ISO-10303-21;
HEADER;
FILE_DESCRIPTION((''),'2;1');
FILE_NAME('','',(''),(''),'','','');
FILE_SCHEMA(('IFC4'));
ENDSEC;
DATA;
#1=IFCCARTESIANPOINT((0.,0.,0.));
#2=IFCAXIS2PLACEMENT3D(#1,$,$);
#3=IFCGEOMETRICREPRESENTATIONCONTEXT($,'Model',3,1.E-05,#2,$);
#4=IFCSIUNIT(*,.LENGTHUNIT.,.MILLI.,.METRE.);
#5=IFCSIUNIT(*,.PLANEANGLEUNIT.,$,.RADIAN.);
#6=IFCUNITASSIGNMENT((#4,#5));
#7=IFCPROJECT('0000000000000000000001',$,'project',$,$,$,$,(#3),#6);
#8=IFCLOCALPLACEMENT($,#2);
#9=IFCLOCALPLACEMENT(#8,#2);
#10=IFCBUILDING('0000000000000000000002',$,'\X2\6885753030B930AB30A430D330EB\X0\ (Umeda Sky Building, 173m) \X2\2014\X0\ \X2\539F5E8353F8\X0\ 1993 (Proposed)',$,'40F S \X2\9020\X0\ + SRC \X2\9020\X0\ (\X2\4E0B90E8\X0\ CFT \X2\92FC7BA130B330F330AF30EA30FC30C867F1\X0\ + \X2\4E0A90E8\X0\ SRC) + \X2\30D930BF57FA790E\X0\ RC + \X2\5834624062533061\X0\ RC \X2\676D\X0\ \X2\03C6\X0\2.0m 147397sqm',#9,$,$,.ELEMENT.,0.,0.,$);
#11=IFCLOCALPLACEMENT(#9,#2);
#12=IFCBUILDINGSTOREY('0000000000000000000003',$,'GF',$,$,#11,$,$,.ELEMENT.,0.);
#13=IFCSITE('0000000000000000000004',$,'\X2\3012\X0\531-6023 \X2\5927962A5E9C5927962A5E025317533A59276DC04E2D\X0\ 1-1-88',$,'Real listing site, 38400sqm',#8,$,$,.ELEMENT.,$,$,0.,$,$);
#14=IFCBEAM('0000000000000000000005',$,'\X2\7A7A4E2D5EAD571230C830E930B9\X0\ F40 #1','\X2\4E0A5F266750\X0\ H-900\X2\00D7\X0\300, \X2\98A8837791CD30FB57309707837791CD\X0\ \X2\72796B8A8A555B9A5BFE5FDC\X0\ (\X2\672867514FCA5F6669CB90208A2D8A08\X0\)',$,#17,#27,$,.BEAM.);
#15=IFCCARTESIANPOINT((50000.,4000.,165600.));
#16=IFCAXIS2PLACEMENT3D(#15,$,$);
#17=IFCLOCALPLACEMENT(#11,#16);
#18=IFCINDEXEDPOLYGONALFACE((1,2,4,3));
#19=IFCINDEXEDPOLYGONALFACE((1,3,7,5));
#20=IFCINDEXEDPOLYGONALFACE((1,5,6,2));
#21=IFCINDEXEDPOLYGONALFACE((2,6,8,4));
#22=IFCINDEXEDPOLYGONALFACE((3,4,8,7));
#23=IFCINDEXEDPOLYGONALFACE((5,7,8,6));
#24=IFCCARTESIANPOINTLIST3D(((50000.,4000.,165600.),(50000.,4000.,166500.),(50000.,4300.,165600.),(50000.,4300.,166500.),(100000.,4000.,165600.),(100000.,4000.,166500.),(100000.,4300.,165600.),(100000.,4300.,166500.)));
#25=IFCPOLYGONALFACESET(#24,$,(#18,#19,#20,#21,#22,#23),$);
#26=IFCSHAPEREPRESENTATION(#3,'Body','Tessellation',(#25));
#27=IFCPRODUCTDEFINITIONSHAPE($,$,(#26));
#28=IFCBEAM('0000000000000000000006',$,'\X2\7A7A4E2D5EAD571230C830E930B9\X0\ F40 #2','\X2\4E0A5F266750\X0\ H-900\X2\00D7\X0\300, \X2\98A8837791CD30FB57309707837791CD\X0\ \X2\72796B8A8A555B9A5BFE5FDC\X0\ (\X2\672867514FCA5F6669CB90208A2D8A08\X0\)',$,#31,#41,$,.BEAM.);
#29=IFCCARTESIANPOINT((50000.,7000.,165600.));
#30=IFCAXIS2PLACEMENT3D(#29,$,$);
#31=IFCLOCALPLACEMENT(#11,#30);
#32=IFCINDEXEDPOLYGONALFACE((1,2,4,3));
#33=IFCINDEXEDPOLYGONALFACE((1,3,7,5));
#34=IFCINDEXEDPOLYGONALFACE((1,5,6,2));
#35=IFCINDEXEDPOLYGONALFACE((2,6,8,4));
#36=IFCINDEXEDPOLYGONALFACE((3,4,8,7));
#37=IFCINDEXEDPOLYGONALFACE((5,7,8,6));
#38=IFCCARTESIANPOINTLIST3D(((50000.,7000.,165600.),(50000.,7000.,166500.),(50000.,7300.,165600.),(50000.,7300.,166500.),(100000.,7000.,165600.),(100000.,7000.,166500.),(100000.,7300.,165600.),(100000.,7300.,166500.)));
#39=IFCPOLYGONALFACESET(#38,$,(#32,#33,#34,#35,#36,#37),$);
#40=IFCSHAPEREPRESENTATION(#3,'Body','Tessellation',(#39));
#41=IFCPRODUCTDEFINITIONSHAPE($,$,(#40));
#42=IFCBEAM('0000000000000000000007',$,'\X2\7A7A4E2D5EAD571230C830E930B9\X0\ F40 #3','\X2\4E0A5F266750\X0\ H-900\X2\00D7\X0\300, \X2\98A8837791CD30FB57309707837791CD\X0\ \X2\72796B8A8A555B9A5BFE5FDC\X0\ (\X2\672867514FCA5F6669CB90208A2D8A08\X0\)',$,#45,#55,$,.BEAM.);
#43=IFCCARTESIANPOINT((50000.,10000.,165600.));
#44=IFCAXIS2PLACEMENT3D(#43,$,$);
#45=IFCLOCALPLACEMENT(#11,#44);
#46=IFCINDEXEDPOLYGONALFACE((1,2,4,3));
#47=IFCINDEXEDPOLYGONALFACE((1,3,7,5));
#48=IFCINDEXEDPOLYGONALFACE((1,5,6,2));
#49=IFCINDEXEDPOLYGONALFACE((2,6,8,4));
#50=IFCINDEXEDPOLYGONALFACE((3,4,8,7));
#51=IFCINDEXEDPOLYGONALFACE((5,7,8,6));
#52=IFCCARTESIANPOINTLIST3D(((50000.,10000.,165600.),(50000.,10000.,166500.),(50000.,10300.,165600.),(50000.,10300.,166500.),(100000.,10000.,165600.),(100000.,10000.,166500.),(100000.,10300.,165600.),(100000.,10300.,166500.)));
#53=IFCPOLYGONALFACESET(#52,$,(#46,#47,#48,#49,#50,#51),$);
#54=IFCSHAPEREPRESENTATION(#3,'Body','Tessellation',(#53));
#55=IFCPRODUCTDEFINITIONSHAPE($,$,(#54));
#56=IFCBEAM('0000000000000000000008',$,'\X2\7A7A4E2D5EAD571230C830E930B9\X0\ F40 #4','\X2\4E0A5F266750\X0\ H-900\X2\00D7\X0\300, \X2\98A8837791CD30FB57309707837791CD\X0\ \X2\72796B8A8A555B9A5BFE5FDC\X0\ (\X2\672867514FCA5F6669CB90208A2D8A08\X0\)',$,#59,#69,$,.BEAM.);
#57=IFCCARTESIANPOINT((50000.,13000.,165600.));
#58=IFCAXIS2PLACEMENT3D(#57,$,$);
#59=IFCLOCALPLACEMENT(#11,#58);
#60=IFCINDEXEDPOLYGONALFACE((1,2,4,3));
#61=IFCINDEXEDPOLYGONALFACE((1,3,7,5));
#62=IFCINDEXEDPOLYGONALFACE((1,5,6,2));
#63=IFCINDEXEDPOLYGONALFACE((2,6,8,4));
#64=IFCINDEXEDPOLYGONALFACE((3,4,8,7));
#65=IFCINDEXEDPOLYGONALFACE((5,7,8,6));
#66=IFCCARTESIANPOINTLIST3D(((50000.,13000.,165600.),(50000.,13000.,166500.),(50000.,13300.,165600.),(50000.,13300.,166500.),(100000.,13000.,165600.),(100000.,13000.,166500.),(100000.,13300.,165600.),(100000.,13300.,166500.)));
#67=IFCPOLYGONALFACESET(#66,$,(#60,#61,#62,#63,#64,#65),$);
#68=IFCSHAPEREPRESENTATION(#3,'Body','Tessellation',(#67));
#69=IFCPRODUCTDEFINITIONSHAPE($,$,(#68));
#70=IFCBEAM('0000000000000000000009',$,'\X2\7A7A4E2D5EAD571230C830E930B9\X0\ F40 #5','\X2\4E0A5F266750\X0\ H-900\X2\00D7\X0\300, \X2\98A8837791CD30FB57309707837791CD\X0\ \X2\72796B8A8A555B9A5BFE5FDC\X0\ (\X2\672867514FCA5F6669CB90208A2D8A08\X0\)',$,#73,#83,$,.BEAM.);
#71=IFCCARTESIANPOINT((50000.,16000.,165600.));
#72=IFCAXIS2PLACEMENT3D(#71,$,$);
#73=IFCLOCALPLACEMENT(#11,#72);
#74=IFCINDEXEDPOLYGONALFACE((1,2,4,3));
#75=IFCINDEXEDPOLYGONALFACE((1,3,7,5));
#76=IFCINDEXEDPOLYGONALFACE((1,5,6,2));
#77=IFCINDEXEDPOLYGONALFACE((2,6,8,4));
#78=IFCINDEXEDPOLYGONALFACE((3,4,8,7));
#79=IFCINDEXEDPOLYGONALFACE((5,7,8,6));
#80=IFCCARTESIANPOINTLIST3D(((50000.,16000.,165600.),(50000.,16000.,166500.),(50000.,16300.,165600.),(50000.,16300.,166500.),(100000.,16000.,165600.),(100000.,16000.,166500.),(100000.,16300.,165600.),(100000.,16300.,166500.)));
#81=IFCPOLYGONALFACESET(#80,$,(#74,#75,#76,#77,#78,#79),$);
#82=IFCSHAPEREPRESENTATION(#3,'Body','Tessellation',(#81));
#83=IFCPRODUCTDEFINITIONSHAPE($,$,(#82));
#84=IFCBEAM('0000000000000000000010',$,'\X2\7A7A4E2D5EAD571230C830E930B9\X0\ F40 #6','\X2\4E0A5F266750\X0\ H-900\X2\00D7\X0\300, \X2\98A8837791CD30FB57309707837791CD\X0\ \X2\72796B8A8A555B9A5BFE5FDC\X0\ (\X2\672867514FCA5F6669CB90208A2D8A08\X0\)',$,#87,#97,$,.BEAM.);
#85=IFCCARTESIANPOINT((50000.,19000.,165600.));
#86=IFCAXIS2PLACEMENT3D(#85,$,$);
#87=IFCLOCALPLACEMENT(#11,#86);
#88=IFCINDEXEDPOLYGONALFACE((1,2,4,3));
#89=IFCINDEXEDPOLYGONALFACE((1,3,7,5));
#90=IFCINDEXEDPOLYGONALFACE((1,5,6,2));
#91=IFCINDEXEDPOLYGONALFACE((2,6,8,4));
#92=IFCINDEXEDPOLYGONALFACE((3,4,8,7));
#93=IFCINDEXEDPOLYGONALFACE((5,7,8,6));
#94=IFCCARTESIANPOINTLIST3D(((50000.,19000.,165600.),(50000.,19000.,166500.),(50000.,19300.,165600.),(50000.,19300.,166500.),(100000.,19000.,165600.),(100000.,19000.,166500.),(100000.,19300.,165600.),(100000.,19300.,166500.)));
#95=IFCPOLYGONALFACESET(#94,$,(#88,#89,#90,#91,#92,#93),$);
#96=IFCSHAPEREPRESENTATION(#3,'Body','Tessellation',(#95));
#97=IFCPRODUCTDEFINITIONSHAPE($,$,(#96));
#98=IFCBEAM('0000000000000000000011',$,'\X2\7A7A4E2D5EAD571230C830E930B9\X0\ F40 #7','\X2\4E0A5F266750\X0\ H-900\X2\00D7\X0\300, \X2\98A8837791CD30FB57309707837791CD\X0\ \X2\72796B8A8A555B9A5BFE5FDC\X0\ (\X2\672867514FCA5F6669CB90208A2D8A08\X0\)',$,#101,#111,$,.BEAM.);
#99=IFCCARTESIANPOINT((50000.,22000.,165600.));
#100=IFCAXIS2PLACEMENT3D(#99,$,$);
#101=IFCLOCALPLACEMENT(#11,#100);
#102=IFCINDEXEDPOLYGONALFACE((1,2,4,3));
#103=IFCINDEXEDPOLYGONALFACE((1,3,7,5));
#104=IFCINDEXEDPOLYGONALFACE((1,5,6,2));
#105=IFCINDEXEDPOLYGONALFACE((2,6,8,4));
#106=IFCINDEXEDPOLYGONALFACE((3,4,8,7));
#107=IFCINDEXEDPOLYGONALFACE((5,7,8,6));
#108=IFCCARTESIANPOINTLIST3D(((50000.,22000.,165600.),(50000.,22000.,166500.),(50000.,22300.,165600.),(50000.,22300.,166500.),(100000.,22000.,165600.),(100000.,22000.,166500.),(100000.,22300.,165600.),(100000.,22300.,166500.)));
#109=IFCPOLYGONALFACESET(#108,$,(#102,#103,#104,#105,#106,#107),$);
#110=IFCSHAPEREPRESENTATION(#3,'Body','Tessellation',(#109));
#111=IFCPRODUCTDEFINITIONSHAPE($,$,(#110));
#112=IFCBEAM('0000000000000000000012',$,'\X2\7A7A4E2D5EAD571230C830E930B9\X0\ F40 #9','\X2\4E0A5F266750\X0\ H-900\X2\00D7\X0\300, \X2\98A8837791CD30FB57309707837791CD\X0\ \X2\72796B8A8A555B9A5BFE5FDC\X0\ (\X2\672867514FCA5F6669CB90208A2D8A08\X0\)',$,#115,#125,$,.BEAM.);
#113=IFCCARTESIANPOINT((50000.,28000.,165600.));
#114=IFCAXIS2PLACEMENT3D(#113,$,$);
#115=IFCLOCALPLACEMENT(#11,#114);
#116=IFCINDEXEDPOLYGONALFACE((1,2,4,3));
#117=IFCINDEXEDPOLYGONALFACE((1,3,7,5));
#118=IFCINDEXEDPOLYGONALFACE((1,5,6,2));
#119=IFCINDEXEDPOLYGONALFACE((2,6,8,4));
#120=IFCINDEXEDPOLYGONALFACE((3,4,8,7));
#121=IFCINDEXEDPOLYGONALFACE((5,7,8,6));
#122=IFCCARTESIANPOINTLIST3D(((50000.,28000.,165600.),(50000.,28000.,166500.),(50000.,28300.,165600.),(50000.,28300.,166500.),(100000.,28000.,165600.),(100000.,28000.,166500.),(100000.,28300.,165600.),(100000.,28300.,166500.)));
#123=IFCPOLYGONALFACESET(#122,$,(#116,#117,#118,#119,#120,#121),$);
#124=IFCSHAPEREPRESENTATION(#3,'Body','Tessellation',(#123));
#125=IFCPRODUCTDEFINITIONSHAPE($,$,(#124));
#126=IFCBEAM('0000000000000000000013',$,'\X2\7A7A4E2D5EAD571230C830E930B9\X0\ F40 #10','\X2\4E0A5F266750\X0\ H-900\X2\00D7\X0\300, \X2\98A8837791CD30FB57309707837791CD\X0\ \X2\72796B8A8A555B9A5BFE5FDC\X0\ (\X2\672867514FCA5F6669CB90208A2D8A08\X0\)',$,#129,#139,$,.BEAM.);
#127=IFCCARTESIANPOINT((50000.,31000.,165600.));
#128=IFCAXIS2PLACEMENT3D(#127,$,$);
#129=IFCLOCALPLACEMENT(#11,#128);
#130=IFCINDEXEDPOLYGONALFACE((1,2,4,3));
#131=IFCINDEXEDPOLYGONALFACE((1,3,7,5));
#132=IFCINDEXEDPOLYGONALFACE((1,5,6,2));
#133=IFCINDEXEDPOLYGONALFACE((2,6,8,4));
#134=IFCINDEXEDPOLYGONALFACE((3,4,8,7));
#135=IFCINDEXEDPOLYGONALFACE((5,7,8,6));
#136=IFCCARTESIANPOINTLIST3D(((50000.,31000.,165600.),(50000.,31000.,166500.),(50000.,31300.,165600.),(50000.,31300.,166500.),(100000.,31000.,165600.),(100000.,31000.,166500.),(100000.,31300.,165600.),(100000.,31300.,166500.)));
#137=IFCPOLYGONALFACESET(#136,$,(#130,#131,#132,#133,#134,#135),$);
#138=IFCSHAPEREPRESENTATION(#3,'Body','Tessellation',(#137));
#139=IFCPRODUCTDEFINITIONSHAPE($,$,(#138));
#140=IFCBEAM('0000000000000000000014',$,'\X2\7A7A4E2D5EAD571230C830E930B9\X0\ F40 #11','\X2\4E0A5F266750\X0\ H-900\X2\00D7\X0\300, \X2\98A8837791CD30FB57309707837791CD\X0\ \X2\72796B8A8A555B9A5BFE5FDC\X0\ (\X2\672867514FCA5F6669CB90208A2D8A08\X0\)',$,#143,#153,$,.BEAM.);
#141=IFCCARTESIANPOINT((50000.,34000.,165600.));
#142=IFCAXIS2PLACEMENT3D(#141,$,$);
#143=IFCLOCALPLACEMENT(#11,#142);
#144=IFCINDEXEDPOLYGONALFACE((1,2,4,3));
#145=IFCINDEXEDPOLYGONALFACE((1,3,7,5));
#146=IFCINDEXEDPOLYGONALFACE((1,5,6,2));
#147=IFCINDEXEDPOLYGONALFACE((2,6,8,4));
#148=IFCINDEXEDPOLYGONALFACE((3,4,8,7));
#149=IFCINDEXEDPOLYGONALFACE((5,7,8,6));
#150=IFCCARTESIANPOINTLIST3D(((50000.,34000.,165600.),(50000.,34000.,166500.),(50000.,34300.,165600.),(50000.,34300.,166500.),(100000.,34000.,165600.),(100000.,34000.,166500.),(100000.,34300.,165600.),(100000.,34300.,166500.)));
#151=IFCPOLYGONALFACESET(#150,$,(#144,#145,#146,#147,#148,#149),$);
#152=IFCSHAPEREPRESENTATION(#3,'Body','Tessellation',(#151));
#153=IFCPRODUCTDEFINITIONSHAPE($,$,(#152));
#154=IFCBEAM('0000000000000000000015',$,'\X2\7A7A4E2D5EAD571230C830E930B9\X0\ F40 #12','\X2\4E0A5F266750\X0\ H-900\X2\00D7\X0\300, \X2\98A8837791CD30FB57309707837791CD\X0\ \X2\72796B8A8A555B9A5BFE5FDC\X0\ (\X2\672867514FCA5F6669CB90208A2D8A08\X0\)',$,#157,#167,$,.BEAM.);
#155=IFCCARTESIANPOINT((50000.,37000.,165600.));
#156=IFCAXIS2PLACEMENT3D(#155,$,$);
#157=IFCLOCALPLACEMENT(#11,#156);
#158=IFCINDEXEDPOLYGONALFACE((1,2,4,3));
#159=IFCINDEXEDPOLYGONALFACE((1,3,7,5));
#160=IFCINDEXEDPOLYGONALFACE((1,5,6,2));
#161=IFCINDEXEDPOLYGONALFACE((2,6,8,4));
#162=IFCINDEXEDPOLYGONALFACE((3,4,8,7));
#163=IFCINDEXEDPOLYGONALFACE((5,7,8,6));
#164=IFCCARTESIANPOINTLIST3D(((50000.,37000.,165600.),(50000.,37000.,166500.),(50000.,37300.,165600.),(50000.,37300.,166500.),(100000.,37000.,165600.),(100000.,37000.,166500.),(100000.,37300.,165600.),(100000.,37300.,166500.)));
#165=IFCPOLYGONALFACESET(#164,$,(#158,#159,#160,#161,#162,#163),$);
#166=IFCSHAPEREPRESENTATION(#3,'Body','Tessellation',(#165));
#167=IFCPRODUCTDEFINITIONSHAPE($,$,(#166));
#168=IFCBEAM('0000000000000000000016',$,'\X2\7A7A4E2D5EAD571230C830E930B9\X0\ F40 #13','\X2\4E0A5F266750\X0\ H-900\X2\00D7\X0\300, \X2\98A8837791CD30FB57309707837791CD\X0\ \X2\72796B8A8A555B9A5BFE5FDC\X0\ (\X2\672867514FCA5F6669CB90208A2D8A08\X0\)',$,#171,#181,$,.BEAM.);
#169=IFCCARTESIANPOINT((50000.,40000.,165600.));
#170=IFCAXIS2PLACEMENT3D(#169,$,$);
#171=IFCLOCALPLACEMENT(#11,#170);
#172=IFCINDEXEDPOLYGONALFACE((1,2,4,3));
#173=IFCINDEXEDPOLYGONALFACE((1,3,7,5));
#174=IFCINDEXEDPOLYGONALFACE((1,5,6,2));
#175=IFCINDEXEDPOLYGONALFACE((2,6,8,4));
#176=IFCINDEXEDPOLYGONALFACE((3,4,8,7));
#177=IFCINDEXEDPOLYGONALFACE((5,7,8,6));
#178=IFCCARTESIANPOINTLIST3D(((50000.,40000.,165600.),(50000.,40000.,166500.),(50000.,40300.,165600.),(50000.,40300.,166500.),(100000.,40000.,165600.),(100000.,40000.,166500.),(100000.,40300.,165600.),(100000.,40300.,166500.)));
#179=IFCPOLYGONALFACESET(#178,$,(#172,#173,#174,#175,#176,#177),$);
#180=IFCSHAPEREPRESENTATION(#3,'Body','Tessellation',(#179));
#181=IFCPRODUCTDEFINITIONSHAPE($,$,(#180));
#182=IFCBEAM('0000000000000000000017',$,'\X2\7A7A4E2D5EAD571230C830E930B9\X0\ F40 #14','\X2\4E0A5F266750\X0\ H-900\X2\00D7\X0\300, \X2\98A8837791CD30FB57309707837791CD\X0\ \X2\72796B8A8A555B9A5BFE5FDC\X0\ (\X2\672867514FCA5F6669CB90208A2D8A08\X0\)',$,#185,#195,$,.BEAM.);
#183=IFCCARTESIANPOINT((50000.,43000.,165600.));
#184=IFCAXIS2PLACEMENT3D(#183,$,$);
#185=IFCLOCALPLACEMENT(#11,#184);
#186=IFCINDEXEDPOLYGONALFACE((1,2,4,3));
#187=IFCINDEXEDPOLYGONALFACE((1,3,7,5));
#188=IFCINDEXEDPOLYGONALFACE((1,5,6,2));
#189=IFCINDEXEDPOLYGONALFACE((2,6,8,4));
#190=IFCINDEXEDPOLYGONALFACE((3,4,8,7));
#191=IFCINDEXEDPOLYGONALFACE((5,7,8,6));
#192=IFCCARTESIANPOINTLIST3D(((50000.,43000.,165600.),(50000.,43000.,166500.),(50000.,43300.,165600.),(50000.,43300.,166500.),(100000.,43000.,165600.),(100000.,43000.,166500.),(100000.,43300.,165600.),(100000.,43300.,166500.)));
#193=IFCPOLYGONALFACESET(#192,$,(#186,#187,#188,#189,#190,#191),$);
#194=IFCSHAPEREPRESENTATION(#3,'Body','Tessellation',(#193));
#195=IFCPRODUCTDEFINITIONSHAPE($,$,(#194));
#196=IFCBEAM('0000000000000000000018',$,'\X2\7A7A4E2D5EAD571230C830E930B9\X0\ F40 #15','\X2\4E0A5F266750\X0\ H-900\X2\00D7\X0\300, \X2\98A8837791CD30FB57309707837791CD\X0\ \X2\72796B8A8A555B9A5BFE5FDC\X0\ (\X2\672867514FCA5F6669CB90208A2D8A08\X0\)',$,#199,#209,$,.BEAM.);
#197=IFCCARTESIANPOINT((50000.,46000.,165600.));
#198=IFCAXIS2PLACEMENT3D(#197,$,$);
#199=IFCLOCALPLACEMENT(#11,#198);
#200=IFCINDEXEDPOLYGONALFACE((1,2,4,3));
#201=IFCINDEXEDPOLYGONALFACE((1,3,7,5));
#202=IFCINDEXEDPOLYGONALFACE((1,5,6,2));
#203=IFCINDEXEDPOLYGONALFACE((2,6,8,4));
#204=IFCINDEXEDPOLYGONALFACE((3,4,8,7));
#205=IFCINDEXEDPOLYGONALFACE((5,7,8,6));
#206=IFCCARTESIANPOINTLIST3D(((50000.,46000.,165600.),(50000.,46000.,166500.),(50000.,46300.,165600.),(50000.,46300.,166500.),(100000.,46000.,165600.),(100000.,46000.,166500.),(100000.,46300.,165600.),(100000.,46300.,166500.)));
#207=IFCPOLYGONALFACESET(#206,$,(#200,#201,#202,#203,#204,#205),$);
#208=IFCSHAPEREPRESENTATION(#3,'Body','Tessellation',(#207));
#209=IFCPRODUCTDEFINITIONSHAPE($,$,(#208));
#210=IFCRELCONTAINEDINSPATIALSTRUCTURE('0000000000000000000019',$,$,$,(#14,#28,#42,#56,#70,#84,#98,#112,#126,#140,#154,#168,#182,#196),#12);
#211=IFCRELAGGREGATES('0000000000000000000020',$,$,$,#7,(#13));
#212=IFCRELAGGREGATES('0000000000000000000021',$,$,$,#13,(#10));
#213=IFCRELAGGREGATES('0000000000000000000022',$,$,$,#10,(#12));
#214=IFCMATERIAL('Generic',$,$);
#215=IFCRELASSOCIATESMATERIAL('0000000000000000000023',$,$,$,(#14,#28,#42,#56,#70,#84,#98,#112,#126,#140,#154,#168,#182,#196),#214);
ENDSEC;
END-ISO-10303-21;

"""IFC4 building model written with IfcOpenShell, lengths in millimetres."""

from ifc_helpers import new_model, si_unit, frame, frame_2d, origin, place, context, project, spatial, rectangle, extrude, material, element, save


model = new_model("IFC4")

# Units and contexts
model_context = context("Model", 3, precision=1e-05, world=origin())
ifc_project = project(units=[si_unit("LENGTHUNIT", "METRE", prefix="MILLI"), si_unit("PLANEANGLEUNIT", "RADIAN")], contexts=[model_context])

# Site, building, storey
site_placement = place(None, origin())
site = spatial("IfcSite", under=ifc_project, at=site_placement, Name="〒531-6023 大阪府大阪市北区大淀中 1-1-88", ObjectType="Real listing site, 38400sqm", CompositionType="ELEMENT", RefElevation=0.0)
building_placement = place(site_placement, origin())
building = spatial("IfcBuilding", under=site, at=building_placement, Name="梅田スカイビル (Umeda Sky Building, 173m) — 原広司 1993 (Proposed)", ObjectType="40F S 造 + SRC 造 (下部 CFT 鋼管コンクリート柱 + 上部 SRC) + ベタ基礎 RC + 場所打ち RC 杭 φ2.0m 147397sqm", CompositionType="ELEMENT", ElevationOfRefHeight=0.0, ElevationOfTerrain=0.0)
storey_placement = place(building_placement, origin())
storey = spatial("IfcBuildingStorey", under=building, at=storey_placement, Name="GF", CompositionType="ELEMENT", Elevation=0.0)

# Beams
ifc_material_1 = material(Name="Generic")
beam_1_placement = place(storey_placement, frame((50000.0, 4000.0, 165600.0)))
element("IfcBeam", 1, at=beam_1_placement, inside=storey, material=ifc_material_1, Name="空中庭園トラス F40 #1", Description="上弦材 H-900×300, 風荷重・地震荷重 特殊評定対応 (木村俊彦構造設計)", PredefinedType="BEAM", context=model_context, shape_type="SweptSolid", body=[
    extrude(rectangle(XDim=50000.0, YDim=300.0, at=frame_2d((25000.0, 150.0))), frame((50000.0, 4000.0, 165600.0)), (0.0, 0.0, 1.0), 900.0),
])
beam_2_placement = place(storey_placement, frame((50000.0, 7000.0, 165600.0)))
element("IfcBeam", 2, at=beam_2_placement, inside=storey, material=ifc_material_1, Name="空中庭園トラス F40 #2", Description="上弦材 H-900×300, 風荷重・地震荷重 特殊評定対応 (木村俊彦構造設計)", PredefinedType="BEAM", context=model_context, shape_type="SweptSolid", body=[
    extrude(rectangle(XDim=50000.0, YDim=300.0, at=frame_2d((25000.0, 150.0))), frame((50000.0, 7000.0, 165600.0)), (0.0, 0.0, 1.0), 900.0),
])
beam_3_placement = place(storey_placement, frame((50000.0, 10000.0, 165600.0)))
element("IfcBeam", 3, at=beam_3_placement, inside=storey, material=ifc_material_1, Name="空中庭園トラス F40 #3", Description="上弦材 H-900×300, 風荷重・地震荷重 特殊評定対応 (木村俊彦構造設計)", PredefinedType="BEAM", context=model_context, shape_type="SweptSolid", body=[
    extrude(rectangle(XDim=50000.0, YDim=300.0, at=frame_2d((25000.0, 150.0))), frame((50000.0, 10000.0, 165600.0)), (0.0, 0.0, 1.0), 900.0),
])
beam_4_placement = place(storey_placement, frame((50000.0, 13000.0, 165600.0)))
element("IfcBeam", 4, at=beam_4_placement, inside=storey, material=ifc_material_1, Name="空中庭園トラス F40 #4", Description="上弦材 H-900×300, 風荷重・地震荷重 特殊評定対応 (木村俊彦構造設計)", PredefinedType="BEAM", context=model_context, shape_type="SweptSolid", body=[
    extrude(rectangle(XDim=50000.0, YDim=300.0, at=frame_2d((25000.0, 150.0))), frame((50000.0, 13000.0, 165600.0)), (0.0, 0.0, 1.0), 900.0),
])
beam_5_placement = place(storey_placement, frame((50000.0, 16000.0, 165600.0)))
element("IfcBeam", 5, at=beam_5_placement, inside=storey, material=ifc_material_1, Name="空中庭園トラス F40 #5", Description="上弦材 H-900×300, 風荷重・地震荷重 特殊評定対応 (木村俊彦構造設計)", PredefinedType="BEAM", context=model_context, shape_type="SweptSolid", body=[
    extrude(rectangle(XDim=50000.0, YDim=300.0, at=frame_2d((25000.0, 150.0))), frame((50000.0, 16000.0, 165600.0)), (0.0, 0.0, 1.0), 900.0),
])
beam_6_placement = place(storey_placement, frame((50000.0, 19000.0, 165600.0)))
element("IfcBeam", 6, at=beam_6_placement, inside=storey, material=ifc_material_1, Name="空中庭園トラス F40 #6", Description="上弦材 H-900×300, 風荷重・地震荷重 特殊評定対応 (木村俊彦構造設計)", PredefinedType="BEAM", context=model_context, shape_type="SweptSolid", body=[
    extrude(rectangle(XDim=50000.0, YDim=300.0, at=frame_2d((25000.0, 150.0))), frame((50000.0, 19000.0, 165600.0)), (0.0, 0.0, 1.0), 900.0),
])
beam_7_placement = place(storey_placement, frame((50000.0, 22000.0, 165600.0)))
element("IfcBeam", 7, at=beam_7_placement, inside=storey, material=ifc_material_1, Name="空中庭園トラス F40 #7", Description="上弦材 H-900×300, 風荷重・地震荷重 特殊評定対応 (木村俊彦構造設計)", PredefinedType="BEAM", context=model_context, shape_type="SweptSolid", body=[
    extrude(rectangle(XDim=50000.0, YDim=300.0, at=frame_2d((25000.0, 150.0))), frame((50000.0, 22000.0, 165600.0)), (0.0, 0.0, 1.0), 900.0),
])
beam_8_placement = place(storey_placement, frame((50000.0, 28000.0, 165600.0)))
element("IfcBeam", 8, at=beam_8_placement, inside=storey, material=ifc_material_1, Name="空中庭園トラス F40 #9", Description="上弦材 H-900×300, 風荷重・地震荷重 特殊評定対応 (木村俊彦構造設計)", PredefinedType="BEAM", context=model_context, shape_type="SweptSolid", body=[
    extrude(rectangle(XDim=50000.0, YDim=300.0, at=frame_2d((25000.0, 150.0))), frame((50000.0, 28000.0, 165600.0)), (0.0, 0.0, 1.0), 900.0),
])
beam_9_placement = place(storey_placement, frame((50000.0, 31000.0, 165600.0)))
element("IfcBeam", 9, at=beam_9_placement, inside=storey, material=ifc_material_1, Name="空中庭園トラス F40 #10", Description="上弦材 H-900×300, 風荷重・地震荷重 特殊評定対応 (木村俊彦構造設計)", PredefinedType="BEAM", context=model_context, shape_type="SweptSolid", body=[
    extrude(rectangle(XDim=50000.0, YDim=300.0, at=frame_2d((25000.0, 150.0))), frame((50000.0, 31000.0, 165600.0)), (0.0, 0.0, 1.0), 900.0),
])
beam_10_placement = place(storey_placement, frame((50000.0, 34000.0, 165600.0)))
element("IfcBeam", 10, at=beam_10_placement, inside=storey, material=ifc_material_1, Name="空中庭園トラス F40 #11", Description="上弦材 H-900×300, 風荷重・地震荷重 特殊評定対応 (木村俊彦構造設計)", PredefinedType="BEAM", context=model_context, shape_type="SweptSolid", body=[
    extrude(rectangle(XDim=50000.0, YDim=300.0, at=frame_2d((25000.0, 150.0))), frame((50000.0, 34000.0, 165600.0)), (0.0, 0.0, 1.0), 900.0),
])
beam_11_placement = place(storey_placement, frame((50000.0, 37000.0, 165600.0)))
element("IfcBeam", 11, at=beam_11_placement, inside=storey, material=ifc_material_1, Name="空中庭園トラス F40 #12", Description="上弦材 H-900×300, 風荷重・地震荷重 特殊評定対応 (木村俊彦構造設計)", PredefinedType="BEAM", context=model_context, shape_type="SweptSolid", body=[
    extrude(rectangle(XDim=50000.0, YDim=300.0, at=frame_2d((25000.0, 150.0))), frame((50000.0, 37000.0, 165600.0)), (0.0, 0.0, 1.0), 900.0),
])
beam_12_placement = place(storey_placement, frame((50000.0, 40000.0, 165600.0)))
element("IfcBeam", 12, at=beam_12_placement, inside=storey, material=ifc_material_1, Name="空中庭園トラス F40 #13", Description="上弦材 H-900×300, 風荷重・地震荷重 特殊評定対応 (木村俊彦構造設計)", PredefinedType="BEAM", context=model_context, shape_type="SweptSolid", body=[
    extrude(rectangle(XDim=50000.0, YDim=300.0, at=frame_2d((25000.0, 150.0))), frame((50000.0, 40000.0, 165600.0)), (0.0, 0.0, 1.0), 900.0),
])
beam_13_placement = place(storey_placement, frame((50000.0, 43000.0, 165600.0)))
element("IfcBeam", 13, at=beam_13_placement, inside=storey, material=ifc_material_1, Name="空中庭園トラス F40 #14", Description="上弦材 H-900×300, 風荷重・地震荷重 特殊評定対応 (木村俊彦構造設計)", PredefinedType="BEAM", context=model_context, shape_type="SweptSolid", body=[
    extrude(rectangle(XDim=50000.0, YDim=300.0, at=frame_2d((25000.0, 150.0))), frame((50000.0, 43000.0, 165600.0)), (0.0, 0.0, 1.0), 900.0),
])
beam_14_placement = place(storey_placement, frame((50000.0, 46000.0, 165600.0)))
element("IfcBeam", 14, at=beam_14_placement, inside=storey, material=ifc_material_1, Name="空中庭園トラス F40 #15", Description="上弦材 H-900×300, 風荷重・地震荷重 特殊評定対応 (木村俊彦構造設計)", PredefinedType="BEAM", context=model_context, shape_type="SweptSolid", body=[
    extrude(rectangle(XDim=50000.0, YDim=300.0, at=frame_2d((25000.0, 150.0))), frame((50000.0, 46000.0, 165600.0)), (0.0, 0.0, 1.0), 900.0),
])

save(model, "model.ifc")
